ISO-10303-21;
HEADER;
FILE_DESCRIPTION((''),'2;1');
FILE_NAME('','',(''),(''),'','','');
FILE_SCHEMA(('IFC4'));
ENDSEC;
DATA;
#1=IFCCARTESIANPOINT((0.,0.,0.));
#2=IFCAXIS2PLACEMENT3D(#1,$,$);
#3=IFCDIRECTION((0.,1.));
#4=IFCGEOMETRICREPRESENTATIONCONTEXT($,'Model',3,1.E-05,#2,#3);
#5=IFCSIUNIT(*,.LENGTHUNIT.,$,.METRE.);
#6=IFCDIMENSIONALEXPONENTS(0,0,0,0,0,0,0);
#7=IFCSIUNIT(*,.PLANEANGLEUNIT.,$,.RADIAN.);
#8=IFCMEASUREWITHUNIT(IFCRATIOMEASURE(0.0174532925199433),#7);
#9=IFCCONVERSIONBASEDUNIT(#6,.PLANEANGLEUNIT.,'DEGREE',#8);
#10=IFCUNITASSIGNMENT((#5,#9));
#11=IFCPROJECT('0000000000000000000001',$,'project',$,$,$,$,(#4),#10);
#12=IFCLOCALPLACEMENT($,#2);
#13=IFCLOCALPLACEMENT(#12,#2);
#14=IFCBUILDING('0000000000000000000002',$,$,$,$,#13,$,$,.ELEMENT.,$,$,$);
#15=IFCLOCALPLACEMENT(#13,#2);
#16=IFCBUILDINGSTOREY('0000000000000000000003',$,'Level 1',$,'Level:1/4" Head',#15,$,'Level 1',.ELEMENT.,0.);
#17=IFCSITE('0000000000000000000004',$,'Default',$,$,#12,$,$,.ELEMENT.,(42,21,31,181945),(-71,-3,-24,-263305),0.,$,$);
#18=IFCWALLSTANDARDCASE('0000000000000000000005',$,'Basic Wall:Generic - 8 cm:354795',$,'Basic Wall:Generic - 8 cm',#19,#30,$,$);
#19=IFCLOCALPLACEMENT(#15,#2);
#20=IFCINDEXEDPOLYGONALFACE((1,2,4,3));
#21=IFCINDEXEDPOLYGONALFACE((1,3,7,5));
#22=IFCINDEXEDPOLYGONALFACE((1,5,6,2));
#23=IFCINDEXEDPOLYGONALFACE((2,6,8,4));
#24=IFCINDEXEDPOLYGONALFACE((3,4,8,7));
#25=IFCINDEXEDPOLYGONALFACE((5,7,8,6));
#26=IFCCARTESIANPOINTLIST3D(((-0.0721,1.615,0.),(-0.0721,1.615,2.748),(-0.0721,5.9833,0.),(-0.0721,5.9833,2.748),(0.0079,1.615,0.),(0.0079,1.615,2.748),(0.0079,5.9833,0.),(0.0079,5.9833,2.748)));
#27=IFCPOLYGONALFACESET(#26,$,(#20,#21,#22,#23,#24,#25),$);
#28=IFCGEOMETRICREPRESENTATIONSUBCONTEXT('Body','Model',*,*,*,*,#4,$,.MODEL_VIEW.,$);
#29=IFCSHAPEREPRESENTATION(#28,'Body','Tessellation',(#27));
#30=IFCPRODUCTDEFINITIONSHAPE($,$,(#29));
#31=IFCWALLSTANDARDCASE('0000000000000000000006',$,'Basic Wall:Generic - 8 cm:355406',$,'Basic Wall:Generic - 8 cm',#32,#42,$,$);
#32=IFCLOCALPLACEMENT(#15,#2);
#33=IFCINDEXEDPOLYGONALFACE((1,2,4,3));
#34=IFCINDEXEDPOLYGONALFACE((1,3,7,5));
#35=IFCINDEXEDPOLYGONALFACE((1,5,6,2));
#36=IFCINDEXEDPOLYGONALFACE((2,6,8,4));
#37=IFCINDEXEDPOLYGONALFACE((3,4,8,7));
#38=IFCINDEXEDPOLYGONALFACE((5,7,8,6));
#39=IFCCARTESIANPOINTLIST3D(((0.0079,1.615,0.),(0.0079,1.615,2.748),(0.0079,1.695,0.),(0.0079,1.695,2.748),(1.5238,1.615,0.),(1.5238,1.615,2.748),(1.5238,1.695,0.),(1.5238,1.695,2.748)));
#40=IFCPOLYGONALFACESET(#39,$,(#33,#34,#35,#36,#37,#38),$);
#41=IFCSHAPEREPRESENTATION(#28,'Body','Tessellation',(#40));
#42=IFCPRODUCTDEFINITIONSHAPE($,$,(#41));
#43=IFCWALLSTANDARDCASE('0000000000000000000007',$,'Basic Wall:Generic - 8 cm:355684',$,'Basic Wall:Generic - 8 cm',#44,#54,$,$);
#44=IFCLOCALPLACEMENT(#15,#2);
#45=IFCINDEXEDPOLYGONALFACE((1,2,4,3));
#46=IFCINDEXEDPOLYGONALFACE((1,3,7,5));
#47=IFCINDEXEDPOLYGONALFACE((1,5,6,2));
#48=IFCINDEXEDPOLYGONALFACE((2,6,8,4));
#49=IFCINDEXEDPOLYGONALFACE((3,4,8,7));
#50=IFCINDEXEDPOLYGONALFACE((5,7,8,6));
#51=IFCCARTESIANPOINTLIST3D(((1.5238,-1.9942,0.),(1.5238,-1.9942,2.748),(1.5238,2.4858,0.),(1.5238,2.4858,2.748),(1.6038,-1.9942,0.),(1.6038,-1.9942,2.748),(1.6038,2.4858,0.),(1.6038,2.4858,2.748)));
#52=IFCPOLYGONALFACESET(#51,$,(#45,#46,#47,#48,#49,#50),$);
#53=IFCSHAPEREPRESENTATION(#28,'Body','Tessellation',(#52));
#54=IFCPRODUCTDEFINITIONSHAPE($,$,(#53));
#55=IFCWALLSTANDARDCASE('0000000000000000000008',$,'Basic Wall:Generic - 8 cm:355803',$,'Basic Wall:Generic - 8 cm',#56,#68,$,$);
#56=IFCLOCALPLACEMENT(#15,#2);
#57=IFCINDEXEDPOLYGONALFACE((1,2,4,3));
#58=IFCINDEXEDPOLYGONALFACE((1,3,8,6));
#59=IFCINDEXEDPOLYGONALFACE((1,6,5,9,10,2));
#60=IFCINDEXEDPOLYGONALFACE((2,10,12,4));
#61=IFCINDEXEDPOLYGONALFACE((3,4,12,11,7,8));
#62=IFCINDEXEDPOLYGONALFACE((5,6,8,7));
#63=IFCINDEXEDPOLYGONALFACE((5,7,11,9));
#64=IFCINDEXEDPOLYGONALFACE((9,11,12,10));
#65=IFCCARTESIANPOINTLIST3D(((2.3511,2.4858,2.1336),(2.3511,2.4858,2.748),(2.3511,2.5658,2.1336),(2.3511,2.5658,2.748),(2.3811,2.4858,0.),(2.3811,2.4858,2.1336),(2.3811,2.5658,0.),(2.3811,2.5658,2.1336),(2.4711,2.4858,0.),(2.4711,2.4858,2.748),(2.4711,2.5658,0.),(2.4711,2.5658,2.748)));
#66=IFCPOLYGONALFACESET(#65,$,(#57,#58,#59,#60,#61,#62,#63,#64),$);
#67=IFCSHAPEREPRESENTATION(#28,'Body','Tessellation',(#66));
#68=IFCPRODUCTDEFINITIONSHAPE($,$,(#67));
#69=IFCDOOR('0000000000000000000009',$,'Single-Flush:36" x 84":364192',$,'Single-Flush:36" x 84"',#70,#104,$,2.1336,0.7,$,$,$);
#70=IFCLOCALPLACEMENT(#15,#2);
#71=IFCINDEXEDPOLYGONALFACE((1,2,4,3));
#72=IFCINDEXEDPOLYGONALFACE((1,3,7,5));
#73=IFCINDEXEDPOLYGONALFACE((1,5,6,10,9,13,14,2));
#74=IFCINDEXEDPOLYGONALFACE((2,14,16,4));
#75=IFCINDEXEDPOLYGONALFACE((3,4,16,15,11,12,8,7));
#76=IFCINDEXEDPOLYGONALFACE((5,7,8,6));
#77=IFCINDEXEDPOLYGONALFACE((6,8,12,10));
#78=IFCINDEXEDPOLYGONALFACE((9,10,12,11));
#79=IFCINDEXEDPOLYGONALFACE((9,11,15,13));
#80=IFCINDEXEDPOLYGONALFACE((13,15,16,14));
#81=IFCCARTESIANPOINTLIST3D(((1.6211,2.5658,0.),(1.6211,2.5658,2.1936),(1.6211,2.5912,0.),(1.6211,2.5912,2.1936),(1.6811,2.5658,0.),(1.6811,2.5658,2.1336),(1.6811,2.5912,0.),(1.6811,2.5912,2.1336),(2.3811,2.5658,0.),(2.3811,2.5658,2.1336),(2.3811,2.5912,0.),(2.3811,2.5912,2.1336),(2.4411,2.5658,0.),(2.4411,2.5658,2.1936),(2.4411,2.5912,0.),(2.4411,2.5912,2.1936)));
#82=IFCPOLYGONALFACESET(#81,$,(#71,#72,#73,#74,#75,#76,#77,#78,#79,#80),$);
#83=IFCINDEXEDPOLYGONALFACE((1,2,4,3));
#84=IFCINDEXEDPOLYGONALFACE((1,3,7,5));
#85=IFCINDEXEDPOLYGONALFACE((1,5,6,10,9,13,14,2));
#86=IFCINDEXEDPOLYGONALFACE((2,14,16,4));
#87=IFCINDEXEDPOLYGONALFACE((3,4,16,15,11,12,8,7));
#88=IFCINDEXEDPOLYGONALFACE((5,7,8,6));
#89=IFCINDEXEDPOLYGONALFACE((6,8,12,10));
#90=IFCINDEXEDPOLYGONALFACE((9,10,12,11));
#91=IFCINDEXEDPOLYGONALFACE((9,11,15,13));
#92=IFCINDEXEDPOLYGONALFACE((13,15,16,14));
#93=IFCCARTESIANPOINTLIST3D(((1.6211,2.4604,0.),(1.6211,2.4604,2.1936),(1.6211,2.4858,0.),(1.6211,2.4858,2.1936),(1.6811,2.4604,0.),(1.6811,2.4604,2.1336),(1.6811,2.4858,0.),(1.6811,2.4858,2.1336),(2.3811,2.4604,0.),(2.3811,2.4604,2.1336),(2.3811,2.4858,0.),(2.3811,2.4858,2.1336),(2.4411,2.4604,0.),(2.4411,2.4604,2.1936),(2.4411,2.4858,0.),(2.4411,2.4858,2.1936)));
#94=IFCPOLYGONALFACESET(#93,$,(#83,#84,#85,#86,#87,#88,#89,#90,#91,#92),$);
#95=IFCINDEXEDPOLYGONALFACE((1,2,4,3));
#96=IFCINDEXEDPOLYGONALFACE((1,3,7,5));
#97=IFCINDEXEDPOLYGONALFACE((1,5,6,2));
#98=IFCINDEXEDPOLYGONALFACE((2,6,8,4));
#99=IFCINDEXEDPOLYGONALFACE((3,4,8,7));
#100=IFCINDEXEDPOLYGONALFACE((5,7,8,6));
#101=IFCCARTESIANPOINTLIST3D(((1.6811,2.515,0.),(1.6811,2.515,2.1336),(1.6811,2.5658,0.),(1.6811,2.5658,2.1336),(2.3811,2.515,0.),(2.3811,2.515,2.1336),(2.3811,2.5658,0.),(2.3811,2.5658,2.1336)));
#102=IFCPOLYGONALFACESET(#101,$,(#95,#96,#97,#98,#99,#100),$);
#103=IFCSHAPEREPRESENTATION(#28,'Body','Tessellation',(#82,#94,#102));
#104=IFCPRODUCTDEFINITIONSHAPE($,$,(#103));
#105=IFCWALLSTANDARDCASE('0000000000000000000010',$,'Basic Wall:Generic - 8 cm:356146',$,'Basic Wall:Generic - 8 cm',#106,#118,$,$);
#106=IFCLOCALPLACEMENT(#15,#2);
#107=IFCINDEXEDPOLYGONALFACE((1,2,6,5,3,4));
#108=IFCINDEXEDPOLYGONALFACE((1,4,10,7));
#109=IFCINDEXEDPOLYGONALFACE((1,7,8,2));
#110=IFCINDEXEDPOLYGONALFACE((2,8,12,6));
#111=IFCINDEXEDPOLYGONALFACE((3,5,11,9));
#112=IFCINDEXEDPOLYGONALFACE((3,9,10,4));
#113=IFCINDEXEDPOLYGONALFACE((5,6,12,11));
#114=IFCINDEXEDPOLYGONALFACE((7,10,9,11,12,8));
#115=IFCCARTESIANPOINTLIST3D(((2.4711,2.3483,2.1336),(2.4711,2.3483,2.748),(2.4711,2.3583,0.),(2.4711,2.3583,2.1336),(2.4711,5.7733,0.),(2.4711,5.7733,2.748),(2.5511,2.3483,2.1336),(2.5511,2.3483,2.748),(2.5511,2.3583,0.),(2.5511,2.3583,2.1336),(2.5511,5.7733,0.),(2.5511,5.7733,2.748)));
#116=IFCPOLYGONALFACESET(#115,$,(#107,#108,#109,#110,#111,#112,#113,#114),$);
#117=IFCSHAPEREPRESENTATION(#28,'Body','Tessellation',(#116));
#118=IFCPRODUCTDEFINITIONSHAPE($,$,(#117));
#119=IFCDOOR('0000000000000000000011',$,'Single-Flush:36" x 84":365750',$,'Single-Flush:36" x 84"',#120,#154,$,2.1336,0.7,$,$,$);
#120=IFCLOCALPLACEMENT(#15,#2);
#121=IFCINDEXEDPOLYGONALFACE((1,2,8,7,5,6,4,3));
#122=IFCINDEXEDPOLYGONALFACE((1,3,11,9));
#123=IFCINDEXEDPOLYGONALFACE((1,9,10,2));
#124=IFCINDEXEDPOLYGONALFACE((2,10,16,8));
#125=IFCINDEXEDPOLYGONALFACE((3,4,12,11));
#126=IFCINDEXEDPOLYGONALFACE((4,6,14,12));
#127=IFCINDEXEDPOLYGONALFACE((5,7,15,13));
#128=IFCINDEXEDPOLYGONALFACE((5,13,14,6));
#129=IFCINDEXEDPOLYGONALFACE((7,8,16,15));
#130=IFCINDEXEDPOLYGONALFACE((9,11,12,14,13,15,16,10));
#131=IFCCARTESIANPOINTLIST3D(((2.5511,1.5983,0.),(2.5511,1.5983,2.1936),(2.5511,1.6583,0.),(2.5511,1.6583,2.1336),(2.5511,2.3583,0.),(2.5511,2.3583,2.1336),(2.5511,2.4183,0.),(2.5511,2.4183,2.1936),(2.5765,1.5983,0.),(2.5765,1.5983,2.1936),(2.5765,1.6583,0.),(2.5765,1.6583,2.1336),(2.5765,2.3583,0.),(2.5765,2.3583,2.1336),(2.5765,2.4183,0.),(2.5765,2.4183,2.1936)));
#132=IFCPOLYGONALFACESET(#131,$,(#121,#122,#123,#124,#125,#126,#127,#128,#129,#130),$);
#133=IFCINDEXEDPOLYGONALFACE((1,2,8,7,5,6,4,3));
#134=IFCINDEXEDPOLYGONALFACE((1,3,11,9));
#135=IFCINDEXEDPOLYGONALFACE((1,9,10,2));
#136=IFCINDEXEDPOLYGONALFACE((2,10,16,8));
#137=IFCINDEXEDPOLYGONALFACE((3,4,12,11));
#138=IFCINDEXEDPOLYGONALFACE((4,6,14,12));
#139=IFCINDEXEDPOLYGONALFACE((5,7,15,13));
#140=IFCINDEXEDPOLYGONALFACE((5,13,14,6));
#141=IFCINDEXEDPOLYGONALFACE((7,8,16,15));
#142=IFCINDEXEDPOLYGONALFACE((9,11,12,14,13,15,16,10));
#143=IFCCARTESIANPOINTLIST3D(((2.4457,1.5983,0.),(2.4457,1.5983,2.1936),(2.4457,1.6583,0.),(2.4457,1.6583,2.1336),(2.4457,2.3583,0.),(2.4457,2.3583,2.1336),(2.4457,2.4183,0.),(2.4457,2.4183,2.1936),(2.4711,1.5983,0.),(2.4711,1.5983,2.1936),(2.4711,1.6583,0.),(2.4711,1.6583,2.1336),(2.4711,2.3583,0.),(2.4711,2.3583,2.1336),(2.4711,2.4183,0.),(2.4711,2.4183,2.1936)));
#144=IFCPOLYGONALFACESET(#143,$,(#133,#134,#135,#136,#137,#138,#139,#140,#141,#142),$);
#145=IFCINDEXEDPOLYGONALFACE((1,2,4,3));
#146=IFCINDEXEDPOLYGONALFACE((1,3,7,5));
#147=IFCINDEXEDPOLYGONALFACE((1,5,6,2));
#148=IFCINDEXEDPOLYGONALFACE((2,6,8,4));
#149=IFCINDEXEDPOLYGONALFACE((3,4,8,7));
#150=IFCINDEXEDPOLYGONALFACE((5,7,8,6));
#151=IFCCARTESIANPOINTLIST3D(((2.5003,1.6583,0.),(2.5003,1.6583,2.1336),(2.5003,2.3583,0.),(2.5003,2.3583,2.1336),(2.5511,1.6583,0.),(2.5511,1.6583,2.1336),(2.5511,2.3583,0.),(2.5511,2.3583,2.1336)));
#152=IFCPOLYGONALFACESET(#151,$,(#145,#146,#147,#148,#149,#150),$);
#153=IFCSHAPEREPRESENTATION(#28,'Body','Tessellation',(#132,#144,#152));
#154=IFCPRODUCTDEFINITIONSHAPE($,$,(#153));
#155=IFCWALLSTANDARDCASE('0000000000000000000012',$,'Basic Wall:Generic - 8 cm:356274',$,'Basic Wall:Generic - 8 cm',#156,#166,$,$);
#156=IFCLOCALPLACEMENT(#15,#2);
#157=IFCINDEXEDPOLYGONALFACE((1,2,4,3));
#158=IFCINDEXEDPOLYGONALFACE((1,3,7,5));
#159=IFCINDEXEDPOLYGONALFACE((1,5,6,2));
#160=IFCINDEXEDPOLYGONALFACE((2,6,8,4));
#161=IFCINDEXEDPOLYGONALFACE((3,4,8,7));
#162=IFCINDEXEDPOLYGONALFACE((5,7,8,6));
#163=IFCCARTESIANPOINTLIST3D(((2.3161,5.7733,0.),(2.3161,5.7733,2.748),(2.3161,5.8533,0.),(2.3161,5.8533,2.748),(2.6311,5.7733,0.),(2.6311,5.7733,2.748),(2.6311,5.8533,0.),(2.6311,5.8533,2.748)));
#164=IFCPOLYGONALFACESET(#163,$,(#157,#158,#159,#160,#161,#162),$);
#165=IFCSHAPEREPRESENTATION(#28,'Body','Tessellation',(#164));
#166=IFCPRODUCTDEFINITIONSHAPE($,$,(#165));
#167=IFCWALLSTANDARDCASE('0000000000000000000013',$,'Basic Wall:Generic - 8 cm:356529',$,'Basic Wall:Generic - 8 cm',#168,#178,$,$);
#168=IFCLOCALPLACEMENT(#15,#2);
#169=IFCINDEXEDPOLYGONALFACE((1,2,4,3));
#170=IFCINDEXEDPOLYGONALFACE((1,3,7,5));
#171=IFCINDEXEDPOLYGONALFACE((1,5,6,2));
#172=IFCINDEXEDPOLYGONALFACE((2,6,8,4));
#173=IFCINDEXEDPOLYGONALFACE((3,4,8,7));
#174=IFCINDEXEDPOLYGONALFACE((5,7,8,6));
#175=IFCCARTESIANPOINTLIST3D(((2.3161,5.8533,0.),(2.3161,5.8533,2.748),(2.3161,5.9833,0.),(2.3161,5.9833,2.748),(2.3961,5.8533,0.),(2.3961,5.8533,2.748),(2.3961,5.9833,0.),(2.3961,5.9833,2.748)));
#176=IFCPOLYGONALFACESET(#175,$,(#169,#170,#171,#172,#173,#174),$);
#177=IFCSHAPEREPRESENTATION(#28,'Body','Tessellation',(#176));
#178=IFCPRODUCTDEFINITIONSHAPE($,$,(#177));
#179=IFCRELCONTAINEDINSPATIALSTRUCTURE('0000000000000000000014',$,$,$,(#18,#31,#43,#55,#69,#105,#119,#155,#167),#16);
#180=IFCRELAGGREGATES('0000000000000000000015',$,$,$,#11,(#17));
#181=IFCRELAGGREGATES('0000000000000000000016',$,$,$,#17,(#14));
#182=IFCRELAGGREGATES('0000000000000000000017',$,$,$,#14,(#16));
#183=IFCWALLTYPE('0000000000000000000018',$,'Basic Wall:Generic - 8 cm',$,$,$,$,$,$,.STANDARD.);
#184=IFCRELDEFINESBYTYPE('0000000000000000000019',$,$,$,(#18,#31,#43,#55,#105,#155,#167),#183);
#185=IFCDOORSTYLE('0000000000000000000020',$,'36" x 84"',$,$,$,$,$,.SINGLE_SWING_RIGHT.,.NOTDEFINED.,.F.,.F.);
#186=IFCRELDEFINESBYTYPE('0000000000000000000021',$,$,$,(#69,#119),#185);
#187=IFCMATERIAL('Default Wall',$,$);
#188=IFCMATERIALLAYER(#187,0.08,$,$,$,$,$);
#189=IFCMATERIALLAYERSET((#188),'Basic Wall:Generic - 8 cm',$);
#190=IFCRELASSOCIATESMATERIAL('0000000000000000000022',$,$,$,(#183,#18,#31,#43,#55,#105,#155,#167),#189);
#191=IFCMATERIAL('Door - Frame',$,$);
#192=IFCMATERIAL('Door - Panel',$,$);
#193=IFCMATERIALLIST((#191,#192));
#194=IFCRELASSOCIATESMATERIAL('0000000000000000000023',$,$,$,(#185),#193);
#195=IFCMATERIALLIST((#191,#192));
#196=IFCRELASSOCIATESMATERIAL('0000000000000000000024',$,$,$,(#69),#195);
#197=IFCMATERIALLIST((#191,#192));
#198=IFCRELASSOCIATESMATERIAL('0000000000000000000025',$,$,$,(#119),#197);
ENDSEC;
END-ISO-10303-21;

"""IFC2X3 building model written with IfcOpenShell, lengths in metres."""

from ifc_helpers import new_model, entity, si_unit, converted_unit, direction, frame, frame_2d, origin, origin_2d_with_axis, place, context, subcontext, project, spatial, polyline, rectangle, outline, extrude, source, transform, mapped, material, material_list, layer, layer_set, layer_usage, type_object, type_shapes, element, fill, save


model = new_model("IFC2X3")

# Units and contexts
model_context = context("Model", 3, precision=1e-05, world=origin(), true_north=direction((0.0, 1.0)))
body_context = subcontext(model_context, "Body", "Model", "MODEL_VIEW")
ifc_project = project(units=[si_unit("LENGTHUNIT", "METRE"), converted_unit("PLANEANGLEUNIT", "DEGREE", entity("IfcRatioMeasure", 0.0174532925199433), si_unit("PLANEANGLEUNIT", "RADIAN"), dimensions=[0, 0, 0, 0, 0, 0, 0])], contexts=[model_context])

# Site, building, storey
site_placement = place(None, origin())
site = spatial("IfcSite", under=ifc_project, at=site_placement, Name="Default", CompositionType="ELEMENT", RefLatitude=(42, 21, 31, 181945), RefLongitude=(-71, -3, -24, -263305), RefElevation=0.0)
building_placement = place(site_placement, origin())
building = spatial("IfcBuilding", under=site, at=building_placement, CompositionType="ELEMENT")
storey_placement = place(building_placement, origin())
storey = spatial("IfcBuildingStorey", under=building, at=storey_placement, Name="Level 1", ObjectType="Level:1/4\" Head", LongName="Level 1", CompositionType="ELEMENT", Elevation=0.0)

# Walls
ifc_material_1 = material(Name="Default Wall")
ifc_layer_1 = layer(ifc_material_1, 0.08)
ifc_layer_set_1 = layer_set([ifc_layer_1], Name="Basic Wall:Generic - 8 cm")
ifc_layer_usage_1 = layer_usage(ifc_layer_set_1, "AXIS2", "NEGATIVE", 0.04)
wall_type = type_object("IfcWallType", Name="Basic Wall:Generic - 8 cm", PredefinedType="STANDARD", material=ifc_layer_set_1)
wall_1_placement = place(storey_placement, frame((-0.0321, 5.9833, 0.0), z_axis=(0.0, 0.0, 1.0), x_axis=(0.0, -1.0, 0.0)))
element("IfcWallStandardCase", 1, at=wall_1_placement, inside=storey, type_object=wall_type, material=ifc_layer_usage_1, Name="Basic Wall:Generic - 8 cm:354795", ObjectType="Basic Wall:Generic - 8 cm", context=body_context, shape_type="SweptSolid", body=[
    extrude(rectangle(XDim=4.3683, YDim=0.08, at=frame_2d((2.1841, 0.0), x_axis=(-1.0, 0.0))), origin(), (0.0, 0.0, 1.0), 2.748),
])
ifc_layer_usage_2 = layer_usage(ifc_layer_set_1, "AXIS2", "NEGATIVE", 0.04)
wall_2_placement = place(storey_placement, frame((0.0079, 1.655, 0.0)))
element("IfcWallStandardCase", 2, at=wall_2_placement, inside=storey, type_object=wall_type, material=ifc_layer_usage_2, Name="Basic Wall:Generic - 8 cm:355406", ObjectType="Basic Wall:Generic - 8 cm", context=body_context, shape_type="SweptSolid", body=[
    extrude(rectangle(XDim=1.5159, YDim=0.08, at=frame_2d((0.7579, 0.0), x_axis=(-1.0, 0.0))), origin(), (0.0, 0.0, 1.0), 2.748),
])
ifc_layer_usage_3 = layer_usage(ifc_layer_set_1, "AXIS2", "NEGATIVE", 0.04)
wall_3_placement = place(storey_placement, frame((1.5638, 2.4858, 0.0), z_axis=(0.0, 0.0, 1.0), x_axis=(0.0, -1.0, 0.0)))
element("IfcWallStandardCase", 3, at=wall_3_placement, inside=storey, type_object=wall_type, material=ifc_layer_usage_3, Name="Basic Wall:Generic - 8 cm:355684", ObjectType="Basic Wall:Generic - 8 cm", context=body_context, shape_type="SweptSolid", body=[
    extrude(rectangle(XDim=4.48, YDim=0.08, at=frame_2d((2.24, 0.0), x_axis=(-1.0, 0.0))), origin(), (0.0, 0.0, 1.0), 2.748),
])

# Walls, openings, doors
ifc_layer_usage_4 = layer_usage(ifc_layer_set_1, "AXIS2", "NEGATIVE", 0.04)
wall_4_placement = place(storey_placement, frame((2.3511, 2.5258, 0.0)))
wall_4 = element("IfcWallStandardCase", 4, at=wall_4_placement, inside=storey, type_object=wall_type, material=ifc_layer_usage_4, Name="Basic Wall:Generic - 8 cm:355803", ObjectType="Basic Wall:Generic - 8 cm", context=body_context, shape_type="SweptSolid", body=[
    extrude(rectangle(XDim=0.12, YDim=0.08, at=frame_2d((0.06, 0.0), x_axis=(-1.0, 0.0))), origin(), (0.0, 0.0, 1.0), 2.748),
])
opening_1_placement = place(wall_4_placement, frame((-0.67, -0.04, 0.0)))
opening_1 = element("IfcOpeningElement", 5, at=opening_1_placement, cuts=wall_4, ObjectType="Opening", context=body_context, shape_type="SweptSolid", body=[
    extrude(rectangle(XDim=0.7, YDim=2.1336, at=frame_2d((1.0668, 0.35), x_axis=(0.0, 1.0))), frame((0.0, 0.0, 0.0), z_axis=(0.0, 1.0, 0.0), x_axis=(0.0, 0.0, 1.0)), (0.0, 0.0, 1.0), 0.08),
])
ifc_material_2 = material(Name="Door - Frame")
ifc_material_3 = material(Name="Door - Panel")
ifc_material_list_1 = material_list([ifc_material_2, ifc_material_3])
ifc_material_list_2 = material_list([ifc_material_2, ifc_material_3])
door_style = type_object("IfcDoorStyle", Name="36\" x 84\"", ConstructionType="NOTDEFINED", OperationType="SINGLE_SWING_RIGHT", ParameterTakesPrecedence=False, Sizeable=False, material=ifc_material_list_2)
shared_shape = source(origin(), body_context, "Body", "SweptSolid", [
    extrude(outline(polyline([(-0.41, -1.1118), (0.41, -1.1118), (0.41, 1.0818), (0.35, 1.0818), (0.35, -1.0518), (-0.35, -1.0518), (-0.35, 1.0818), (-0.41, 1.0818), (-0.41, -1.1118)])), frame((0.35, 0.08, 1.0818), z_axis=(0.0, 1.0, 0.0), x_axis=(1.0, 0.0, 0.0)), (0.0, 0.0, 1.0), 0.0254),
    extrude(outline(polyline([(-1.1118, -0.41), (1.0818, -0.41), (1.0818, -0.35), (-1.0518, -0.35), (-1.0518, 0.35), (1.0818, 0.35), (1.0818, 0.41), (-1.1118, 0.41), (-1.1118, -0.41)])), frame((0.35, -0.0254, 1.0818), z_axis=(0.0, 1.0, 0.0), x_axis=(0.0, 0.0, -1.0)), (0.0, 0.0, 1.0), 0.0254),
    extrude(rectangle(XDim=0.0508, YDim=0.7, at=origin_2d_with_axis()), frame((0.35, 0.0546, 0.0), z_axis=(0.0, 0.0, 1.0), x_axis=(0.0, 1.0, 0.0)), (0.0, 0.0, 1.0), 2.1336),
])
type_shapes(door_style, [shared_shape])
door_1_placement = place(opening_1_placement, origin())
door_1 = element("IfcDoor", 6, at=door_1_placement, inside=storey, type_object=door_style, material=ifc_material_list_1, Name="Single-Flush:36\" x 84\":364192", ObjectType="Single-Flush:36\" x 84\"", OverallHeight=2.1336, OverallWidth=0.7, context=body_context, shape_type="MappedRepresentation", body=[
    mapped(shared_shape, transform((0.0, 0.0, 0.0), scale=1.0)),
])
fill(opening_1, door_1)
ifc_layer_usage_5 = layer_usage(ifc_layer_set_1, "AXIS2", "NEGATIVE", 0.04)
wall_5_placement = place(storey_placement, frame((2.5111, 5.7733, 0.0), z_axis=(0.0, 0.0, 1.0), x_axis=(0.0, -1.0, 0.0)))
wall_5 = element("IfcWallStandardCase", 7, at=wall_5_placement, inside=storey, type_object=wall_type, material=ifc_layer_usage_5, Name="Basic Wall:Generic - 8 cm:356146", ObjectType="Basic Wall:Generic - 8 cm", context=body_context, shape_type="SweptSolid", body=[
    extrude(rectangle(XDim=3.425, YDim=0.08, at=frame_2d((1.7125, 0.0), x_axis=(-1.0, 0.0))), origin(), (0.0, 0.0, 1.0), 2.748),
])
opening_2_placement = place(wall_5_placement, frame((3.415, -0.04, 0.0)))
opening_2 = element("IfcOpeningElement", 8, at=opening_2_placement, cuts=wall_5, ObjectType="Opening", context=body_context, shape_type="SweptSolid", body=[
    extrude(rectangle(XDim=0.7, YDim=2.1336, at=frame_2d((1.0668, 0.35), x_axis=(0.0, 1.0))), frame((0.0, 0.0, 0.0), z_axis=(0.0, 1.0, 0.0), x_axis=(0.0, 0.0, 1.0)), (0.0, 0.0, 1.0), 0.08),
])
ifc_material_list_3 = material_list([ifc_material_2, ifc_material_3])
door_2_placement = place(opening_2_placement, origin())
door_2 = element("IfcDoor", 9, at=door_2_placement, inside=storey, type_object=door_style, material=ifc_material_list_3, Name="Single-Flush:36\" x 84\":365750", ObjectType="Single-Flush:36\" x 84\"", OverallHeight=2.1336, OverallWidth=0.7, context=body_context, shape_type="MappedRepresentation", body=[
    mapped(shared_shape, transform((0.0, 0.0, 0.0), scale=1.0)),
])
fill(opening_2, door_2)

# Walls
ifc_layer_usage_6 = layer_usage(ifc_layer_set_1, "AXIS2", "NEGATIVE", 0.04)
wall_6_placement = place(storey_placement, frame((2.6311, 5.8133, 0.0), z_axis=(0.0, 0.0, 1.0), x_axis=(-1.0, 0.0, 0.0)))
element("IfcWallStandardCase", 10, at=wall_6_placement, inside=storey, type_object=wall_type, material=ifc_layer_usage_6, Name="Basic Wall:Generic - 8 cm:356274", ObjectType="Basic Wall:Generic - 8 cm", context=body_context, shape_type="SweptSolid", body=[
    extrude(rectangle(XDim=0.315, YDim=0.08, at=frame_2d((0.1575, 0.0), x_axis=(-1.0, 0.0))), origin(), (0.0, 0.0, 1.0), 2.748),
])
ifc_layer_usage_7 = layer_usage(ifc_layer_set_1, "AXIS2", "NEGATIVE", 0.04)
wall_7_placement = place(storey_placement, frame((2.3561, 5.8533, 0.0), z_axis=(0.0, 0.0, 1.0), x_axis=(0.0, 1.0, 0.0)))
element("IfcWallStandardCase", 11, at=wall_7_placement, inside=storey, type_object=wall_type, material=ifc_layer_usage_7, Name="Basic Wall:Generic - 8 cm:356529", ObjectType="Basic Wall:Generic - 8 cm", context=body_context, shape_type="SweptSolid", body=[
    extrude(rectangle(XDim=0.13, YDim=0.08, at=frame_2d((0.065, 0.0), x_axis=(-1.0, 0.0))), origin(), (0.0, 0.0, 1.0), 2.748),
])

save(model, "model.ifc")
